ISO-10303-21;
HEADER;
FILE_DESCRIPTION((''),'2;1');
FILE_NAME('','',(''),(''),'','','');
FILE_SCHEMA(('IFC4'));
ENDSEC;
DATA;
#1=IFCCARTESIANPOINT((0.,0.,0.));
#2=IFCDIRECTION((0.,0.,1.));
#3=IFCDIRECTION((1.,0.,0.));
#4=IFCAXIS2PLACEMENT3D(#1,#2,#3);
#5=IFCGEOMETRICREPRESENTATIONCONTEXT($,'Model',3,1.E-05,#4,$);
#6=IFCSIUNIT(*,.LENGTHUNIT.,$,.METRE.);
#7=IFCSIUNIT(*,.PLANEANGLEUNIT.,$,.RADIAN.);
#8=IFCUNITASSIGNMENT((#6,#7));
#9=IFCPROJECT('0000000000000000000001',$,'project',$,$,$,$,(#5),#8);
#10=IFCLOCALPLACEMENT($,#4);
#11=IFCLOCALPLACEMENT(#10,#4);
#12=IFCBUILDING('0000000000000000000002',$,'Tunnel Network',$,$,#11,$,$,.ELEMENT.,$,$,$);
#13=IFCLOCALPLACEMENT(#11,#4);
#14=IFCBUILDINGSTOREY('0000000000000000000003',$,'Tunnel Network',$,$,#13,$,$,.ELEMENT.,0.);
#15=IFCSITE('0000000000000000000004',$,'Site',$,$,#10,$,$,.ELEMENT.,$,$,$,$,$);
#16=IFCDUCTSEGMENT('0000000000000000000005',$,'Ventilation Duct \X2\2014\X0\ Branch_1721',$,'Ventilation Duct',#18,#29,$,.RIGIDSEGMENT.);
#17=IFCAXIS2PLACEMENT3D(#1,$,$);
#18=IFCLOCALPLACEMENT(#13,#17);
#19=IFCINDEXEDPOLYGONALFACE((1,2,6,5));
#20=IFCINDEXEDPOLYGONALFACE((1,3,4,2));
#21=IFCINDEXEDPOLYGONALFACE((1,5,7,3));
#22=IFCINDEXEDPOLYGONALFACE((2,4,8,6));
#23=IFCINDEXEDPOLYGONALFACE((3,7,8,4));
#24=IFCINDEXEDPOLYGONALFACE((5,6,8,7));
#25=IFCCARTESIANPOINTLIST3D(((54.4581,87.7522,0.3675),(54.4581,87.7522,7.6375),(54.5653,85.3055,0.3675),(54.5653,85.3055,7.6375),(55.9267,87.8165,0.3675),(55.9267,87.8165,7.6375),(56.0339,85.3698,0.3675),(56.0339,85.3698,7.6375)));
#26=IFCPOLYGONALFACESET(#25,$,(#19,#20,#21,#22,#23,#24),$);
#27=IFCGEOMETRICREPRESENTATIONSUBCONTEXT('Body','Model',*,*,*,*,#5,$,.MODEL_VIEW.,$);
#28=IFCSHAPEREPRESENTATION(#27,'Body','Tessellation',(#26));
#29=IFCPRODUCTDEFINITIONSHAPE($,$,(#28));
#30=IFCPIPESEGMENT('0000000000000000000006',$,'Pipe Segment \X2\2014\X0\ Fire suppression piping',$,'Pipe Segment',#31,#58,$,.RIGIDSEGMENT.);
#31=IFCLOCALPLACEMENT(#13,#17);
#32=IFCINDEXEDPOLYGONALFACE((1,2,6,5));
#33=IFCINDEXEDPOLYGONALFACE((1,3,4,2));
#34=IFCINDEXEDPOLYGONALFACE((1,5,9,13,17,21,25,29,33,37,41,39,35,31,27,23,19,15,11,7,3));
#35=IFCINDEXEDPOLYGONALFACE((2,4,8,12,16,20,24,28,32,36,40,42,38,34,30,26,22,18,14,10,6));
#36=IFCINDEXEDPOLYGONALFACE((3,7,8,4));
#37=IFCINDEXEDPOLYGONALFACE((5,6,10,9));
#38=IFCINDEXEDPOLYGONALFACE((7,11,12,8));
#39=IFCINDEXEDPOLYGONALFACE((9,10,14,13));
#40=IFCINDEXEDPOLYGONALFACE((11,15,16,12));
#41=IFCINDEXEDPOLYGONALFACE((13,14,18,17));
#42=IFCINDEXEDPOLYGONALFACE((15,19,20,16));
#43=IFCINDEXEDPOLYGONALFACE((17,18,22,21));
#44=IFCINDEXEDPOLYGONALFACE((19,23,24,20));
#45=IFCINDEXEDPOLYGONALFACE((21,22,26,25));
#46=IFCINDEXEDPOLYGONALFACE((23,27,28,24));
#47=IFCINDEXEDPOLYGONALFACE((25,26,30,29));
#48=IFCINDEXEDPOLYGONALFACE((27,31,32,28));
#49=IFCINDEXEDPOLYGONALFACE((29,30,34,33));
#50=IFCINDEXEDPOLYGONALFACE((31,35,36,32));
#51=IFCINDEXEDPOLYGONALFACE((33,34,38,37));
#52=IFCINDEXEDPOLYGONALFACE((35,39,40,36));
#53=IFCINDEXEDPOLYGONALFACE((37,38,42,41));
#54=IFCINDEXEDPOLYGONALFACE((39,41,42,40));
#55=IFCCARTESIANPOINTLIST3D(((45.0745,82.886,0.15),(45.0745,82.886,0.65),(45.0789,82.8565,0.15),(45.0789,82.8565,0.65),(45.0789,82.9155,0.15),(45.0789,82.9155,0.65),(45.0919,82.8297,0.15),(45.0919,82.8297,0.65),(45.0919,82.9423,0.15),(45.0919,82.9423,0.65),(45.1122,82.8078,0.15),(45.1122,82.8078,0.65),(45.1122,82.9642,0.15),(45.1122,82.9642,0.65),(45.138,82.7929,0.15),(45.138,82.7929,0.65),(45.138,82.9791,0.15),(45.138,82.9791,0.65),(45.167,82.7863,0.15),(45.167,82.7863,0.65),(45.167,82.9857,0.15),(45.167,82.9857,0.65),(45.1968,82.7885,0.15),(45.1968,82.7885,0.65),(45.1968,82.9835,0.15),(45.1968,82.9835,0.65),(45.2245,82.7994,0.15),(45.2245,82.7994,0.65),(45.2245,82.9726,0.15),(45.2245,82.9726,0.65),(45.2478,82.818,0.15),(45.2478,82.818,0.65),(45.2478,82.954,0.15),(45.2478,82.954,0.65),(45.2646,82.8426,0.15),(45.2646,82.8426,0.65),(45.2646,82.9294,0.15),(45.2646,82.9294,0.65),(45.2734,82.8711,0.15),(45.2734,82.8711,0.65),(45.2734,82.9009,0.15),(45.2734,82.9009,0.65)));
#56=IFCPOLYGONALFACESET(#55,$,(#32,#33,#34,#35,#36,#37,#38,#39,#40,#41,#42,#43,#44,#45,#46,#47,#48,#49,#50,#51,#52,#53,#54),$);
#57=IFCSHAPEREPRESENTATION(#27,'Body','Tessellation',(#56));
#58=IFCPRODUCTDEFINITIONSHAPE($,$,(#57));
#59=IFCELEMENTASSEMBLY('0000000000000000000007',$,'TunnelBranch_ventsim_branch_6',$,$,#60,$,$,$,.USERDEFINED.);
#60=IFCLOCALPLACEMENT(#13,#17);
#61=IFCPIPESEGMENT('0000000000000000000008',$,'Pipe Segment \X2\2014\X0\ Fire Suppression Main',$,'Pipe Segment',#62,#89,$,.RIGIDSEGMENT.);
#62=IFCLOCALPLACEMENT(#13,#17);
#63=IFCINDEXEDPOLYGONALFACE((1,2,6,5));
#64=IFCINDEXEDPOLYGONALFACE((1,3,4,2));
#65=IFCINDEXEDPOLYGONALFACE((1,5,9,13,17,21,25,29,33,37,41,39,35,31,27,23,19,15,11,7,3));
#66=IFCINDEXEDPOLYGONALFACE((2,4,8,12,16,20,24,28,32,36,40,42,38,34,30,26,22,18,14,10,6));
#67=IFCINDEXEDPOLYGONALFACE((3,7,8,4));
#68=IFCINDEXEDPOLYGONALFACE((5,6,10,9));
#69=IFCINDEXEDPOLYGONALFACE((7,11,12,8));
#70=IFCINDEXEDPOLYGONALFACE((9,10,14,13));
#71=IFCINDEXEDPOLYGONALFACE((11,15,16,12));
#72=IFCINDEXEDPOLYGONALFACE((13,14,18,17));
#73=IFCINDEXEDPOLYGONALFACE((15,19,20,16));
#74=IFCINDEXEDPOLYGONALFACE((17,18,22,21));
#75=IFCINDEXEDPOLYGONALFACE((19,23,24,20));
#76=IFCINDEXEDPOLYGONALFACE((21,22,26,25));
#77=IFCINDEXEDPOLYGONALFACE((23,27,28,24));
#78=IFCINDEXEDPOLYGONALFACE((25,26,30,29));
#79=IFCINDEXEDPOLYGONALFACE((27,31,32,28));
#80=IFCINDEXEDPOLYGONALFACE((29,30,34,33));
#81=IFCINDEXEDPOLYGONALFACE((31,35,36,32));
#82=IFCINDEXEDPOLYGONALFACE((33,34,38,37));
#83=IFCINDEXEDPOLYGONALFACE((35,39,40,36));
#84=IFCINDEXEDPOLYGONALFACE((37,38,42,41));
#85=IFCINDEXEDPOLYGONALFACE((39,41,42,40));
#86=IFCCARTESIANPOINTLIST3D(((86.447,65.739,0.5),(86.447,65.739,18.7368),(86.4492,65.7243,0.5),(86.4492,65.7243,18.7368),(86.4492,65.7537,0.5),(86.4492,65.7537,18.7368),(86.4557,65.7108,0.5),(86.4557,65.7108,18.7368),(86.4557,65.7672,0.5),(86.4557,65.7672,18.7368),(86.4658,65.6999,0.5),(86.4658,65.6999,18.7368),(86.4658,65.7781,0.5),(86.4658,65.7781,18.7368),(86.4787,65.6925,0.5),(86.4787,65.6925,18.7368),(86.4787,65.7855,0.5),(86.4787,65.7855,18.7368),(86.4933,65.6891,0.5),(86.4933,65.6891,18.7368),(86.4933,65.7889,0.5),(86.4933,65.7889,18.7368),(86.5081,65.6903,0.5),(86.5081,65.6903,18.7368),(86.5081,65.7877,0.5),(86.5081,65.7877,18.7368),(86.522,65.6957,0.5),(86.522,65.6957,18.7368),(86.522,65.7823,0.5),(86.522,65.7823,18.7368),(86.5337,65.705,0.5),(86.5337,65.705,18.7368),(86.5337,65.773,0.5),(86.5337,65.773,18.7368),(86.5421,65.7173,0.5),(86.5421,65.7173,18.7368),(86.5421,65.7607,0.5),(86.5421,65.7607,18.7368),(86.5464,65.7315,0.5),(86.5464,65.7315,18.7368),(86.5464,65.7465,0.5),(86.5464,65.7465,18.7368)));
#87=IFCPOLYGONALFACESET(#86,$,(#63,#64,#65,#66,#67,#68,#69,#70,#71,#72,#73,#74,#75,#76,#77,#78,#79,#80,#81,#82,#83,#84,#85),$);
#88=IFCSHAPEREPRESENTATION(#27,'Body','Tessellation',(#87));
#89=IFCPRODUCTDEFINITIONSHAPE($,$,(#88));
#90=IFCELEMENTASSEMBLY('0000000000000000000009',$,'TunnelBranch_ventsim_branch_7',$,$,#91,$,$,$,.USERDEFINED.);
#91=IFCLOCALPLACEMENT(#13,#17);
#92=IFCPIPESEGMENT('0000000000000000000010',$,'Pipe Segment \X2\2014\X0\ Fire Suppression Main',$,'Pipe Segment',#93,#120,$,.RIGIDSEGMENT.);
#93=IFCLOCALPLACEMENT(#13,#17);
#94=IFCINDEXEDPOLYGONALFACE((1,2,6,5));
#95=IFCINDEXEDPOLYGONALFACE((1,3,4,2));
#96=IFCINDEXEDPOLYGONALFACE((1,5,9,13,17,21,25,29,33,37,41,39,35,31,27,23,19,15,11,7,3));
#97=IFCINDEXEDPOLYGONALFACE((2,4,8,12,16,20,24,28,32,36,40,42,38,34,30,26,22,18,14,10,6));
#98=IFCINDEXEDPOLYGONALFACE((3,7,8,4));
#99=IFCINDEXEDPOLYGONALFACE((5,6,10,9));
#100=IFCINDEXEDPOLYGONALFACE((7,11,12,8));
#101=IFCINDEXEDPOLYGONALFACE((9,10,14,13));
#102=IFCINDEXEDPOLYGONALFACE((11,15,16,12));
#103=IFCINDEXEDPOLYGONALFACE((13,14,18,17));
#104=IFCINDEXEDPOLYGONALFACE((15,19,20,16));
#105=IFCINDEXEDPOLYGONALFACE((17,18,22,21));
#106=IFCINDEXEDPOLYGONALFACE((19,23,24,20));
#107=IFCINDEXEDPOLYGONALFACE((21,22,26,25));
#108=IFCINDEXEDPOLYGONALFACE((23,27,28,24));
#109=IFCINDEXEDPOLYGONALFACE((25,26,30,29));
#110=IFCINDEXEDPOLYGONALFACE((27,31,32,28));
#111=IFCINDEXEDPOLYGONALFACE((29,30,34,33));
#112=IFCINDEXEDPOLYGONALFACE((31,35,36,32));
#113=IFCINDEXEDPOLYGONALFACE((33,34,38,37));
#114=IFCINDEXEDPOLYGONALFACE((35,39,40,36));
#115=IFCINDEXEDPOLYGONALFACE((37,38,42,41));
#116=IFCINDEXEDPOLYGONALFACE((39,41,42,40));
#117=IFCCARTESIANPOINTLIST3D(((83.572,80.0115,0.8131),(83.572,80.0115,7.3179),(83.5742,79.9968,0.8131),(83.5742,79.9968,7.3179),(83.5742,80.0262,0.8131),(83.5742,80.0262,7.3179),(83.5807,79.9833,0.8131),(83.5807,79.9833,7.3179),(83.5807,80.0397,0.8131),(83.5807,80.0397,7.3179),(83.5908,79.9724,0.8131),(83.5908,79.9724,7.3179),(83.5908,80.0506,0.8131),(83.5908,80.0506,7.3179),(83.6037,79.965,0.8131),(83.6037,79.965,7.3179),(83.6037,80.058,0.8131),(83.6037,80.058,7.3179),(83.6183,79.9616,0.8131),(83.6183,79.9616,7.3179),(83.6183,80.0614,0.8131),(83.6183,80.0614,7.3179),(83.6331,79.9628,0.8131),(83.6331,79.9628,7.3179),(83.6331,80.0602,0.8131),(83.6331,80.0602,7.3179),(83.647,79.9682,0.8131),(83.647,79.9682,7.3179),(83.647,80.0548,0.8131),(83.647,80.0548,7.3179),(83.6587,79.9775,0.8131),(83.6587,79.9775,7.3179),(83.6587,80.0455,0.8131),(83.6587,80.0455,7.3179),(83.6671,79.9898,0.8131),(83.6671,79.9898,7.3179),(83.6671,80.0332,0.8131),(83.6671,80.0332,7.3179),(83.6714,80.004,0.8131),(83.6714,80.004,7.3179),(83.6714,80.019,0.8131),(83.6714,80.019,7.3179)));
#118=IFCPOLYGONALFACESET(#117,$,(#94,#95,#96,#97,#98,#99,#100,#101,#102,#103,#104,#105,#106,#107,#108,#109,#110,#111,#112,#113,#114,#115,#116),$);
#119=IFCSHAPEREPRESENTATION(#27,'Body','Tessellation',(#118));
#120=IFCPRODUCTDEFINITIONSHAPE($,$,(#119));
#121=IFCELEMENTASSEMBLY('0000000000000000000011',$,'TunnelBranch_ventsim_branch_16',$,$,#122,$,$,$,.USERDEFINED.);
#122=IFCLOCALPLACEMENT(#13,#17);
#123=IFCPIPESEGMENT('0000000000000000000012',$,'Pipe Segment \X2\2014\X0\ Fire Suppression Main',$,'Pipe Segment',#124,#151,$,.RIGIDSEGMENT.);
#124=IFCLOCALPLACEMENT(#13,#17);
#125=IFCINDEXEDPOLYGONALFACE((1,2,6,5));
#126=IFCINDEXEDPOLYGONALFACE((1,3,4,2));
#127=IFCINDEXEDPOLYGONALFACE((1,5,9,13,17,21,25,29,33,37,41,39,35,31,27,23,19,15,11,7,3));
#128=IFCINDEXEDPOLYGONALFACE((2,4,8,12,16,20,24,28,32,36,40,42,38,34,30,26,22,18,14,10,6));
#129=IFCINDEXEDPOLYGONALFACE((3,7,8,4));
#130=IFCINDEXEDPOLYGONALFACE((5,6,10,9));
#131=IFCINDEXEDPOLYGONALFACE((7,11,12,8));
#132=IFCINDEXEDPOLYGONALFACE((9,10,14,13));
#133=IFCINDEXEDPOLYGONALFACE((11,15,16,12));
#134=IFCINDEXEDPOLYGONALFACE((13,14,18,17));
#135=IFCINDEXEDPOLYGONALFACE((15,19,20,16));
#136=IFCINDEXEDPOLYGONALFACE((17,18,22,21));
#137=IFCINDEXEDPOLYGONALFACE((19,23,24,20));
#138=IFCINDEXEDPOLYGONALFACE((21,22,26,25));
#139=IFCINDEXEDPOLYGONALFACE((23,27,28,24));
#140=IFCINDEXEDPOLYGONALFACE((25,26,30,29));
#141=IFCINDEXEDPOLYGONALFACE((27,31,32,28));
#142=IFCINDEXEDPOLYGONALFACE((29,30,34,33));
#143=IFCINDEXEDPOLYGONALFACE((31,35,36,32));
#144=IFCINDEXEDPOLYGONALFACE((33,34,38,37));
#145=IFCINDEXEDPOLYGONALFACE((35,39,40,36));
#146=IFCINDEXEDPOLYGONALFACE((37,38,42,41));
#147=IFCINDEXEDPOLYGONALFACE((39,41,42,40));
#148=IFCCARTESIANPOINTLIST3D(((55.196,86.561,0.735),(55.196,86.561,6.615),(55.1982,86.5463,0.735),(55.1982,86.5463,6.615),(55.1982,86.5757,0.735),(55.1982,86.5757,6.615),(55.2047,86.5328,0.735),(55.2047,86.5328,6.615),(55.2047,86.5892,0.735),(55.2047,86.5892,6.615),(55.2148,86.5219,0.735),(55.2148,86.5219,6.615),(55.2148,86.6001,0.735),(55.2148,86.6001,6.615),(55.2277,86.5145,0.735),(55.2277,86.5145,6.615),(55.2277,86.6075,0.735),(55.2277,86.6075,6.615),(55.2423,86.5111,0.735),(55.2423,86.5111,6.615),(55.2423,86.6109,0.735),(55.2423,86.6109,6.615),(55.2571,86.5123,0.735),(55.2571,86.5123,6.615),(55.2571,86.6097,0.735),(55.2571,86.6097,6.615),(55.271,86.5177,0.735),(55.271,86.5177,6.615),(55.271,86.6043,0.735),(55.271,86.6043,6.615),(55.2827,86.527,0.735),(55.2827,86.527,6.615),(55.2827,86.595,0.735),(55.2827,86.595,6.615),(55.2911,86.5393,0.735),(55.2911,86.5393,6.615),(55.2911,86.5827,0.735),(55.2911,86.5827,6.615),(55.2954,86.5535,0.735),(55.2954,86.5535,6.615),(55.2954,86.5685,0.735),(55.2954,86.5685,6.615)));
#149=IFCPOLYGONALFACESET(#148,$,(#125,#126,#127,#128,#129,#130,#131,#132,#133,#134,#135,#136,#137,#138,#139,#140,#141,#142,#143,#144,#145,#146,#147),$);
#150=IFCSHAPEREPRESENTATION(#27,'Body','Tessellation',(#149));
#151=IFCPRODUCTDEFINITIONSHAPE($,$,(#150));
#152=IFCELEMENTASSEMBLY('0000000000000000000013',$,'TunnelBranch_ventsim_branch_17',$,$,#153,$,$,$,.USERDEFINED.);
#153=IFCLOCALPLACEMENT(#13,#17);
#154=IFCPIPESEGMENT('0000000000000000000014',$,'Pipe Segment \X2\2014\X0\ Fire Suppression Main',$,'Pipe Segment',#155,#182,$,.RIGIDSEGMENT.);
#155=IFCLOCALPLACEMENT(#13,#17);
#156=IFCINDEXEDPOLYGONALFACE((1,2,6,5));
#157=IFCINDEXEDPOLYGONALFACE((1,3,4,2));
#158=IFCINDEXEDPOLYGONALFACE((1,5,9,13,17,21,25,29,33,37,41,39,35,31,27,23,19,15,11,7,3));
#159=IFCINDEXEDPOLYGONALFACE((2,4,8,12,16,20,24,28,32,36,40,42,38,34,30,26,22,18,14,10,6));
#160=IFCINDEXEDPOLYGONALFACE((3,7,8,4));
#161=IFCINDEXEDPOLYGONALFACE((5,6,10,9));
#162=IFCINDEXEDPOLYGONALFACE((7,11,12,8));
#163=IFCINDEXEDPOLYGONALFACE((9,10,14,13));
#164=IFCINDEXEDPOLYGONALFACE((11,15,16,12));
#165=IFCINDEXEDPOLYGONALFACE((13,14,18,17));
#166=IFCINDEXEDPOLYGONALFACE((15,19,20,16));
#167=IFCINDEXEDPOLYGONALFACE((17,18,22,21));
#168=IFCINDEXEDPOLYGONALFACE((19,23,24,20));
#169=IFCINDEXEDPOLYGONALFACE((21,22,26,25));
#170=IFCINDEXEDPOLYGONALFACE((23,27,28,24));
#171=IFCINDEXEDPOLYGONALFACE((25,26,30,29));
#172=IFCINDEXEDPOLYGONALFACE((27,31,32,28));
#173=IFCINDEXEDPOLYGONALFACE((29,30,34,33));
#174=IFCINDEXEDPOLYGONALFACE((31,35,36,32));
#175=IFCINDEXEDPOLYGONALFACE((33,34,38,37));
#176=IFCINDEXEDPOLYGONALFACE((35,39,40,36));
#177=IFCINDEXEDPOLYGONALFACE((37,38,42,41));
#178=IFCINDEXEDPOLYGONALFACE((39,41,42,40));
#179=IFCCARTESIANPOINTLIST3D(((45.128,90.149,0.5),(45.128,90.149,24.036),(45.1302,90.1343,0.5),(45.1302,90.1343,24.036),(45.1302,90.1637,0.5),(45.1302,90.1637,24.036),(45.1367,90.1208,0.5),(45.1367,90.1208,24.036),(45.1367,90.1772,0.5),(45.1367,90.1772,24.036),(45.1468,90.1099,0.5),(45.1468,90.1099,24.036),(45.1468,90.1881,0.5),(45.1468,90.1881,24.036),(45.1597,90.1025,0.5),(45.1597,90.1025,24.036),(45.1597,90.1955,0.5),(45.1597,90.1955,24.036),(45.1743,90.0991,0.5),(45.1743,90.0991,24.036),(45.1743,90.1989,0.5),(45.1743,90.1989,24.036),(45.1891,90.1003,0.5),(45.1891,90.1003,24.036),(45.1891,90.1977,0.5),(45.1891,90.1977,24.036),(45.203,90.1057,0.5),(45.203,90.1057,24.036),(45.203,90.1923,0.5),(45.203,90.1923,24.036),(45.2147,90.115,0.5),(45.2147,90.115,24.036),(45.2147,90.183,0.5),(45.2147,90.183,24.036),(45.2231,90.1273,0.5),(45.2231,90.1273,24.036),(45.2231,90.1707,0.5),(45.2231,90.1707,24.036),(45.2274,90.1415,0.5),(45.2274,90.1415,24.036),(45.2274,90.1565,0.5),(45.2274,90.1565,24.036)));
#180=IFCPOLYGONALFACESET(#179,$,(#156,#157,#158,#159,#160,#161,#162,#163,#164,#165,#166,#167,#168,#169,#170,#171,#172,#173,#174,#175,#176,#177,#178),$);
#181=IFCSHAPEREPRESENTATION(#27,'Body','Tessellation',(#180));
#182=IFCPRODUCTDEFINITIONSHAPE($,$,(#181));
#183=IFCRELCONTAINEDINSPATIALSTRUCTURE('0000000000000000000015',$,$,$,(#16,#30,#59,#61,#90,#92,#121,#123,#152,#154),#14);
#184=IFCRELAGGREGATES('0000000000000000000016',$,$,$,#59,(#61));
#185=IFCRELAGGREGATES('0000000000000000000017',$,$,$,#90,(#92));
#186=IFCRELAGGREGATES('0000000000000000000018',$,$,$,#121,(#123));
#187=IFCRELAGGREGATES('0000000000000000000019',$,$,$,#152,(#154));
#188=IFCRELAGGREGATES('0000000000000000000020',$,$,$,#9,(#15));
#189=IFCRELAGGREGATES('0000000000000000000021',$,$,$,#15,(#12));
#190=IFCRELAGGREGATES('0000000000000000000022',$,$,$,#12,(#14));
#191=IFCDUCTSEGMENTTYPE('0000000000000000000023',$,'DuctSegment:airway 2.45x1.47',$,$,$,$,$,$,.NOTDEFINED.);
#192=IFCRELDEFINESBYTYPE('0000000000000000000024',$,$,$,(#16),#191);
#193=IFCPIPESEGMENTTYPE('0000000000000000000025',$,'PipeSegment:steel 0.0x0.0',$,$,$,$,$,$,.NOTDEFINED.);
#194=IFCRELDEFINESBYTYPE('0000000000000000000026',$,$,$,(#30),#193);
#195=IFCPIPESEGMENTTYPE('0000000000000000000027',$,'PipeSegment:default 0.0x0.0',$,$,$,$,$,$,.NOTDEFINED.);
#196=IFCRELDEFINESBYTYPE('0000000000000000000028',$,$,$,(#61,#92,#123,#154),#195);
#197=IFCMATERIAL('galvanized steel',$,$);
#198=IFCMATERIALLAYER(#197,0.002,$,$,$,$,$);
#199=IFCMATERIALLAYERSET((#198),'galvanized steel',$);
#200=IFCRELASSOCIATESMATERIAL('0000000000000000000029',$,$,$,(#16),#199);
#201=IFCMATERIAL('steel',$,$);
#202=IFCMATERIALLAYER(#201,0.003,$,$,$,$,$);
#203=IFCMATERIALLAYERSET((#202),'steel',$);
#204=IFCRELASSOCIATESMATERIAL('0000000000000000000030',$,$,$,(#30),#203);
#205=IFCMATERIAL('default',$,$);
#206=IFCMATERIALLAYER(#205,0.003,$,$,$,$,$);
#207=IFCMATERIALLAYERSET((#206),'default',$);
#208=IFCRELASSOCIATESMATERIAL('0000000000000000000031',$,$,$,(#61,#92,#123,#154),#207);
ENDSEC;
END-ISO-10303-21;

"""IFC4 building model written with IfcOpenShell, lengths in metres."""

from ifc_helpers import new_model, si_unit, frame, origin_with_axes, origin_2d_with_axis, place, context, subcontext, project, spatial, rectangle, circle, extrude, material, layer, layer_set, layer_usage, type_object, element, aggregate, save


model = new_model("IFC4")

# Units and contexts
model_context = context("Model", 3, precision=1e-05, world=origin_with_axes())
body_context = subcontext(model_context, "Body", "Model", "MODEL_VIEW")
ifc_project = project(units=[si_unit("LENGTHUNIT", "METRE"), si_unit("PLANEANGLEUNIT", "RADIAN")], contexts=[model_context])

# Site, building, storey
site_placement = place(None, origin_with_axes())
site = spatial("IfcSite", under=ifc_project, at=site_placement, Name="Site", CompositionType="ELEMENT")
building_placement = place(site_placement, origin_with_axes())
building = spatial("IfcBuilding", under=site, at=building_placement, Name="Tunnel Network", CompositionType="ELEMENT")
storey_placement = place(building_placement, origin_with_axes())
storey = spatial("IfcBuildingStorey", under=building, at=storey_placement, Name="Tunnel Network", CompositionType="ELEMENT", Elevation=0.0)

# Duct segment
ifc_material_1 = material(Name="galvanized steel")
ifc_layer_1 = layer(ifc_material_1, 0.002)
ifc_layer_set_1 = layer_set([ifc_layer_1], Name="galvanized steel")
ifc_layer_usage_1 = layer_usage(ifc_layer_set_1, "AXIS2", "POSITIVE", 0.0)
duct_segment_type = type_object("IfcDuctSegmentType", Name="DuctSegment:airway 2.45x1.47")
duct_segment_placement = place(storey_placement, frame((55.246, 86.561, 0.3675), z_axis=(0.0, 0.0, 1.0), x_axis=(-0.043741, 0.999043, 0.0)))
element("IfcDuctSegment", 1, at=duct_segment_placement, inside=storey, type_object=duct_segment_type, material=ifc_layer_usage_1, Name="Ventilation Duct — Branch_1721", ObjectType="Ventilation Duct", PredefinedType="RIGIDSEGMENT", context=body_context, shape_type="SweptSolid", body=[
    extrude(rectangle(XDim=2.449, YDim=1.47, at=origin_2d_with_axis()), origin_with_axes(), (0.0, 0.0, 1.0), 7.27),
])

# Pipe segment
ifc_material_2 = material(Name="steel")
ifc_layer_2 = layer(ifc_material_2, 0.003)
ifc_layer_set_2 = layer_set([ifc_layer_2], Name="steel")
ifc_layer_usage_2 = layer_usage(ifc_layer_set_2, "AXIS2", "POSITIVE", 0.0)
pipe_segment_type_1 = type_object("IfcPipeSegmentType", Name="PipeSegment:steel 0.0x0.0")
pipe_segment_1_placement = place(storey_placement, frame((45.1745, 82.886, 0.15), z_axis=(0.0, 0.0, 1.0), x_axis=(-1.0, 0.0, 0.0)))
element("IfcPipeSegment", 2, at=pipe_segment_1_placement, inside=storey, type_object=pipe_segment_type_1, material=ifc_layer_usage_2, Name="Pipe Segment — Fire suppression piping", ObjectType="Pipe Segment", PredefinedType="RIGIDSEGMENT", context=body_context, shape_type="SweptSolid", body=[
    extrude(circle(Radius=0.1, at=origin_2d_with_axis()), origin_with_axes(), (0.0, 0.0, 1.0), 0.5),
])

# Element assemblies, pipe segments
assembly_1_placement = place(storey_placement, frame((86.497, 65.739, 1.25), z_axis=(0.0, 1.0, 0.0), x_axis=(-1.0, 0.0, 0.0)))
assembly_1 = element("IfcElementAssembly", 3, at=assembly_1_placement, inside=storey, Name="TunnelBranch_ventsim_branch_6", PredefinedType="USERDEFINED")
ifc_material_3 = material(Name="default")
ifc_layer_3 = layer(ifc_material_3, 0.003)
ifc_layer_set_3 = layer_set([ifc_layer_3], Name="default")
ifc_layer_usage_3 = layer_usage(ifc_layer_set_3, "AXIS2", "POSITIVE", 0.0)
pipe_segment_type_2 = type_object("IfcPipeSegmentType", Name="PipeSegment:default 0.0x0.0")
pipe_segment_2_placement = place(storey_placement, frame((86.497, 65.739, 0.5), z_axis=(0.0, 0.0, 1.0), x_axis=(-1.0, 0.0, 0.0)))
pipe_segment_2 = element("IfcPipeSegment", 4, at=pipe_segment_2_placement, inside=storey, type_object=pipe_segment_type_2, material=ifc_layer_usage_3, Name="Pipe Segment — Fire Suppression Main", ObjectType="Pipe Segment", PredefinedType="RIGIDSEGMENT", context=body_context, shape_type="SweptSolid", body=[
    extrude(circle(Radius=0.05, at=origin_2d_with_axis()), origin_with_axes(), (0.0, 0.0, 1.0), 18.2368),
])
aggregate(assembly_1, [pipe_segment_2])
assembly_2_placement = place(storey_placement, frame((83.622, 80.0115, 0.8131), z_axis=(0.0, 0.0, 1.0), x_axis=(-1.0, 0.0, 0.0)))
assembly_2 = element("IfcElementAssembly", 5, at=assembly_2_placement, inside=storey, Name="TunnelBranch_ventsim_branch_7", PredefinedType="USERDEFINED")
ifc_layer_usage_4 = layer_usage(ifc_layer_set_3, "AXIS2", "POSITIVE", 0.0)
pipe_segment_3_placement = place(storey_placement, frame((83.622, 80.0115, 0.8131), z_axis=(0.0, 0.0, 1.0), x_axis=(-1.0, 0.0, 0.0)))
pipe_segment_3 = element("IfcPipeSegment", 6, at=pipe_segment_3_placement, inside=storey, type_object=pipe_segment_type_2, material=ifc_layer_usage_4, Name="Pipe Segment — Fire Suppression Main", ObjectType="Pipe Segment", PredefinedType="RIGIDSEGMENT", context=body_context, shape_type="SweptSolid", body=[
    extrude(circle(Radius=0.05, at=origin_2d_with_axis()), origin_with_axes(), (0.0, 0.0, 1.0), 6.5048),
])
aggregate(assembly_2, [pipe_segment_3])
assembly_3_placement = place(storey_placement, frame((55.246, 86.561, 0.735), z_axis=(0.0, 0.0, 1.0), x_axis=(-1.0, 0.0, 0.0)))
assembly_3 = element("IfcElementAssembly", 7, at=assembly_3_placement, inside=storey, Name="TunnelBranch_ventsim_branch_16", PredefinedType="USERDEFINED")
ifc_layer_usage_5 = layer_usage(ifc_layer_set_3, "AXIS2", "POSITIVE", 0.0)
pipe_segment_4_placement = place(storey_placement, frame((55.246, 86.561, 0.735), z_axis=(0.0, 0.0, 1.0), x_axis=(-1.0, 0.0, 0.0)))
pipe_segment_4 = element("IfcPipeSegment", 8, at=pipe_segment_4_placement, inside=storey, type_object=pipe_segment_type_2, material=ifc_layer_usage_5, Name="Pipe Segment — Fire Suppression Main", ObjectType="Pipe Segment", PredefinedType="RIGIDSEGMENT", context=body_context, shape_type="SweptSolid", body=[
    extrude(circle(Radius=0.05, at=origin_2d_with_axis()), origin_with_axes(), (0.0, 0.0, 1.0), 5.88),
])
aggregate(assembly_3, [pipe_segment_4])
assembly_4_placement = place(storey_placement, frame((45.178, 90.149, 1.25), z_axis=(0.0, 1.0, 0.0), x_axis=(-1.0, 0.0, 0.0)))
assembly_4 = element("IfcElementAssembly", 9, at=assembly_4_placement, inside=storey, Name="TunnelBranch_ventsim_branch_17", PredefinedType="USERDEFINED")
ifc_layer_usage_6 = layer_usage(ifc_layer_set_3, "AXIS2", "POSITIVE", 0.0)
pipe_segment_5_placement = place(storey_placement, frame((45.178, 90.149, 0.5), z_axis=(0.0, 0.0, 1.0), x_axis=(-1.0, 0.0, 0.0)))
pipe_segment_5 = element("IfcPipeSegment", 10, at=pipe_segment_5_placement, inside=storey, type_object=pipe_segment_type_2, material=ifc_layer_usage_6, Name="Pipe Segment — Fire Suppression Main", ObjectType="Pipe Segment", PredefinedType="RIGIDSEGMENT", context=body_context, shape_type="SweptSolid", body=[
    extrude(circle(Radius=0.05, at=origin_2d_with_axis()), origin_with_axes(), (0.0, 0.0, 1.0), 23.536),
])
aggregate(assembly_4, [pipe_segment_5])

save(model, "model.ifc")
